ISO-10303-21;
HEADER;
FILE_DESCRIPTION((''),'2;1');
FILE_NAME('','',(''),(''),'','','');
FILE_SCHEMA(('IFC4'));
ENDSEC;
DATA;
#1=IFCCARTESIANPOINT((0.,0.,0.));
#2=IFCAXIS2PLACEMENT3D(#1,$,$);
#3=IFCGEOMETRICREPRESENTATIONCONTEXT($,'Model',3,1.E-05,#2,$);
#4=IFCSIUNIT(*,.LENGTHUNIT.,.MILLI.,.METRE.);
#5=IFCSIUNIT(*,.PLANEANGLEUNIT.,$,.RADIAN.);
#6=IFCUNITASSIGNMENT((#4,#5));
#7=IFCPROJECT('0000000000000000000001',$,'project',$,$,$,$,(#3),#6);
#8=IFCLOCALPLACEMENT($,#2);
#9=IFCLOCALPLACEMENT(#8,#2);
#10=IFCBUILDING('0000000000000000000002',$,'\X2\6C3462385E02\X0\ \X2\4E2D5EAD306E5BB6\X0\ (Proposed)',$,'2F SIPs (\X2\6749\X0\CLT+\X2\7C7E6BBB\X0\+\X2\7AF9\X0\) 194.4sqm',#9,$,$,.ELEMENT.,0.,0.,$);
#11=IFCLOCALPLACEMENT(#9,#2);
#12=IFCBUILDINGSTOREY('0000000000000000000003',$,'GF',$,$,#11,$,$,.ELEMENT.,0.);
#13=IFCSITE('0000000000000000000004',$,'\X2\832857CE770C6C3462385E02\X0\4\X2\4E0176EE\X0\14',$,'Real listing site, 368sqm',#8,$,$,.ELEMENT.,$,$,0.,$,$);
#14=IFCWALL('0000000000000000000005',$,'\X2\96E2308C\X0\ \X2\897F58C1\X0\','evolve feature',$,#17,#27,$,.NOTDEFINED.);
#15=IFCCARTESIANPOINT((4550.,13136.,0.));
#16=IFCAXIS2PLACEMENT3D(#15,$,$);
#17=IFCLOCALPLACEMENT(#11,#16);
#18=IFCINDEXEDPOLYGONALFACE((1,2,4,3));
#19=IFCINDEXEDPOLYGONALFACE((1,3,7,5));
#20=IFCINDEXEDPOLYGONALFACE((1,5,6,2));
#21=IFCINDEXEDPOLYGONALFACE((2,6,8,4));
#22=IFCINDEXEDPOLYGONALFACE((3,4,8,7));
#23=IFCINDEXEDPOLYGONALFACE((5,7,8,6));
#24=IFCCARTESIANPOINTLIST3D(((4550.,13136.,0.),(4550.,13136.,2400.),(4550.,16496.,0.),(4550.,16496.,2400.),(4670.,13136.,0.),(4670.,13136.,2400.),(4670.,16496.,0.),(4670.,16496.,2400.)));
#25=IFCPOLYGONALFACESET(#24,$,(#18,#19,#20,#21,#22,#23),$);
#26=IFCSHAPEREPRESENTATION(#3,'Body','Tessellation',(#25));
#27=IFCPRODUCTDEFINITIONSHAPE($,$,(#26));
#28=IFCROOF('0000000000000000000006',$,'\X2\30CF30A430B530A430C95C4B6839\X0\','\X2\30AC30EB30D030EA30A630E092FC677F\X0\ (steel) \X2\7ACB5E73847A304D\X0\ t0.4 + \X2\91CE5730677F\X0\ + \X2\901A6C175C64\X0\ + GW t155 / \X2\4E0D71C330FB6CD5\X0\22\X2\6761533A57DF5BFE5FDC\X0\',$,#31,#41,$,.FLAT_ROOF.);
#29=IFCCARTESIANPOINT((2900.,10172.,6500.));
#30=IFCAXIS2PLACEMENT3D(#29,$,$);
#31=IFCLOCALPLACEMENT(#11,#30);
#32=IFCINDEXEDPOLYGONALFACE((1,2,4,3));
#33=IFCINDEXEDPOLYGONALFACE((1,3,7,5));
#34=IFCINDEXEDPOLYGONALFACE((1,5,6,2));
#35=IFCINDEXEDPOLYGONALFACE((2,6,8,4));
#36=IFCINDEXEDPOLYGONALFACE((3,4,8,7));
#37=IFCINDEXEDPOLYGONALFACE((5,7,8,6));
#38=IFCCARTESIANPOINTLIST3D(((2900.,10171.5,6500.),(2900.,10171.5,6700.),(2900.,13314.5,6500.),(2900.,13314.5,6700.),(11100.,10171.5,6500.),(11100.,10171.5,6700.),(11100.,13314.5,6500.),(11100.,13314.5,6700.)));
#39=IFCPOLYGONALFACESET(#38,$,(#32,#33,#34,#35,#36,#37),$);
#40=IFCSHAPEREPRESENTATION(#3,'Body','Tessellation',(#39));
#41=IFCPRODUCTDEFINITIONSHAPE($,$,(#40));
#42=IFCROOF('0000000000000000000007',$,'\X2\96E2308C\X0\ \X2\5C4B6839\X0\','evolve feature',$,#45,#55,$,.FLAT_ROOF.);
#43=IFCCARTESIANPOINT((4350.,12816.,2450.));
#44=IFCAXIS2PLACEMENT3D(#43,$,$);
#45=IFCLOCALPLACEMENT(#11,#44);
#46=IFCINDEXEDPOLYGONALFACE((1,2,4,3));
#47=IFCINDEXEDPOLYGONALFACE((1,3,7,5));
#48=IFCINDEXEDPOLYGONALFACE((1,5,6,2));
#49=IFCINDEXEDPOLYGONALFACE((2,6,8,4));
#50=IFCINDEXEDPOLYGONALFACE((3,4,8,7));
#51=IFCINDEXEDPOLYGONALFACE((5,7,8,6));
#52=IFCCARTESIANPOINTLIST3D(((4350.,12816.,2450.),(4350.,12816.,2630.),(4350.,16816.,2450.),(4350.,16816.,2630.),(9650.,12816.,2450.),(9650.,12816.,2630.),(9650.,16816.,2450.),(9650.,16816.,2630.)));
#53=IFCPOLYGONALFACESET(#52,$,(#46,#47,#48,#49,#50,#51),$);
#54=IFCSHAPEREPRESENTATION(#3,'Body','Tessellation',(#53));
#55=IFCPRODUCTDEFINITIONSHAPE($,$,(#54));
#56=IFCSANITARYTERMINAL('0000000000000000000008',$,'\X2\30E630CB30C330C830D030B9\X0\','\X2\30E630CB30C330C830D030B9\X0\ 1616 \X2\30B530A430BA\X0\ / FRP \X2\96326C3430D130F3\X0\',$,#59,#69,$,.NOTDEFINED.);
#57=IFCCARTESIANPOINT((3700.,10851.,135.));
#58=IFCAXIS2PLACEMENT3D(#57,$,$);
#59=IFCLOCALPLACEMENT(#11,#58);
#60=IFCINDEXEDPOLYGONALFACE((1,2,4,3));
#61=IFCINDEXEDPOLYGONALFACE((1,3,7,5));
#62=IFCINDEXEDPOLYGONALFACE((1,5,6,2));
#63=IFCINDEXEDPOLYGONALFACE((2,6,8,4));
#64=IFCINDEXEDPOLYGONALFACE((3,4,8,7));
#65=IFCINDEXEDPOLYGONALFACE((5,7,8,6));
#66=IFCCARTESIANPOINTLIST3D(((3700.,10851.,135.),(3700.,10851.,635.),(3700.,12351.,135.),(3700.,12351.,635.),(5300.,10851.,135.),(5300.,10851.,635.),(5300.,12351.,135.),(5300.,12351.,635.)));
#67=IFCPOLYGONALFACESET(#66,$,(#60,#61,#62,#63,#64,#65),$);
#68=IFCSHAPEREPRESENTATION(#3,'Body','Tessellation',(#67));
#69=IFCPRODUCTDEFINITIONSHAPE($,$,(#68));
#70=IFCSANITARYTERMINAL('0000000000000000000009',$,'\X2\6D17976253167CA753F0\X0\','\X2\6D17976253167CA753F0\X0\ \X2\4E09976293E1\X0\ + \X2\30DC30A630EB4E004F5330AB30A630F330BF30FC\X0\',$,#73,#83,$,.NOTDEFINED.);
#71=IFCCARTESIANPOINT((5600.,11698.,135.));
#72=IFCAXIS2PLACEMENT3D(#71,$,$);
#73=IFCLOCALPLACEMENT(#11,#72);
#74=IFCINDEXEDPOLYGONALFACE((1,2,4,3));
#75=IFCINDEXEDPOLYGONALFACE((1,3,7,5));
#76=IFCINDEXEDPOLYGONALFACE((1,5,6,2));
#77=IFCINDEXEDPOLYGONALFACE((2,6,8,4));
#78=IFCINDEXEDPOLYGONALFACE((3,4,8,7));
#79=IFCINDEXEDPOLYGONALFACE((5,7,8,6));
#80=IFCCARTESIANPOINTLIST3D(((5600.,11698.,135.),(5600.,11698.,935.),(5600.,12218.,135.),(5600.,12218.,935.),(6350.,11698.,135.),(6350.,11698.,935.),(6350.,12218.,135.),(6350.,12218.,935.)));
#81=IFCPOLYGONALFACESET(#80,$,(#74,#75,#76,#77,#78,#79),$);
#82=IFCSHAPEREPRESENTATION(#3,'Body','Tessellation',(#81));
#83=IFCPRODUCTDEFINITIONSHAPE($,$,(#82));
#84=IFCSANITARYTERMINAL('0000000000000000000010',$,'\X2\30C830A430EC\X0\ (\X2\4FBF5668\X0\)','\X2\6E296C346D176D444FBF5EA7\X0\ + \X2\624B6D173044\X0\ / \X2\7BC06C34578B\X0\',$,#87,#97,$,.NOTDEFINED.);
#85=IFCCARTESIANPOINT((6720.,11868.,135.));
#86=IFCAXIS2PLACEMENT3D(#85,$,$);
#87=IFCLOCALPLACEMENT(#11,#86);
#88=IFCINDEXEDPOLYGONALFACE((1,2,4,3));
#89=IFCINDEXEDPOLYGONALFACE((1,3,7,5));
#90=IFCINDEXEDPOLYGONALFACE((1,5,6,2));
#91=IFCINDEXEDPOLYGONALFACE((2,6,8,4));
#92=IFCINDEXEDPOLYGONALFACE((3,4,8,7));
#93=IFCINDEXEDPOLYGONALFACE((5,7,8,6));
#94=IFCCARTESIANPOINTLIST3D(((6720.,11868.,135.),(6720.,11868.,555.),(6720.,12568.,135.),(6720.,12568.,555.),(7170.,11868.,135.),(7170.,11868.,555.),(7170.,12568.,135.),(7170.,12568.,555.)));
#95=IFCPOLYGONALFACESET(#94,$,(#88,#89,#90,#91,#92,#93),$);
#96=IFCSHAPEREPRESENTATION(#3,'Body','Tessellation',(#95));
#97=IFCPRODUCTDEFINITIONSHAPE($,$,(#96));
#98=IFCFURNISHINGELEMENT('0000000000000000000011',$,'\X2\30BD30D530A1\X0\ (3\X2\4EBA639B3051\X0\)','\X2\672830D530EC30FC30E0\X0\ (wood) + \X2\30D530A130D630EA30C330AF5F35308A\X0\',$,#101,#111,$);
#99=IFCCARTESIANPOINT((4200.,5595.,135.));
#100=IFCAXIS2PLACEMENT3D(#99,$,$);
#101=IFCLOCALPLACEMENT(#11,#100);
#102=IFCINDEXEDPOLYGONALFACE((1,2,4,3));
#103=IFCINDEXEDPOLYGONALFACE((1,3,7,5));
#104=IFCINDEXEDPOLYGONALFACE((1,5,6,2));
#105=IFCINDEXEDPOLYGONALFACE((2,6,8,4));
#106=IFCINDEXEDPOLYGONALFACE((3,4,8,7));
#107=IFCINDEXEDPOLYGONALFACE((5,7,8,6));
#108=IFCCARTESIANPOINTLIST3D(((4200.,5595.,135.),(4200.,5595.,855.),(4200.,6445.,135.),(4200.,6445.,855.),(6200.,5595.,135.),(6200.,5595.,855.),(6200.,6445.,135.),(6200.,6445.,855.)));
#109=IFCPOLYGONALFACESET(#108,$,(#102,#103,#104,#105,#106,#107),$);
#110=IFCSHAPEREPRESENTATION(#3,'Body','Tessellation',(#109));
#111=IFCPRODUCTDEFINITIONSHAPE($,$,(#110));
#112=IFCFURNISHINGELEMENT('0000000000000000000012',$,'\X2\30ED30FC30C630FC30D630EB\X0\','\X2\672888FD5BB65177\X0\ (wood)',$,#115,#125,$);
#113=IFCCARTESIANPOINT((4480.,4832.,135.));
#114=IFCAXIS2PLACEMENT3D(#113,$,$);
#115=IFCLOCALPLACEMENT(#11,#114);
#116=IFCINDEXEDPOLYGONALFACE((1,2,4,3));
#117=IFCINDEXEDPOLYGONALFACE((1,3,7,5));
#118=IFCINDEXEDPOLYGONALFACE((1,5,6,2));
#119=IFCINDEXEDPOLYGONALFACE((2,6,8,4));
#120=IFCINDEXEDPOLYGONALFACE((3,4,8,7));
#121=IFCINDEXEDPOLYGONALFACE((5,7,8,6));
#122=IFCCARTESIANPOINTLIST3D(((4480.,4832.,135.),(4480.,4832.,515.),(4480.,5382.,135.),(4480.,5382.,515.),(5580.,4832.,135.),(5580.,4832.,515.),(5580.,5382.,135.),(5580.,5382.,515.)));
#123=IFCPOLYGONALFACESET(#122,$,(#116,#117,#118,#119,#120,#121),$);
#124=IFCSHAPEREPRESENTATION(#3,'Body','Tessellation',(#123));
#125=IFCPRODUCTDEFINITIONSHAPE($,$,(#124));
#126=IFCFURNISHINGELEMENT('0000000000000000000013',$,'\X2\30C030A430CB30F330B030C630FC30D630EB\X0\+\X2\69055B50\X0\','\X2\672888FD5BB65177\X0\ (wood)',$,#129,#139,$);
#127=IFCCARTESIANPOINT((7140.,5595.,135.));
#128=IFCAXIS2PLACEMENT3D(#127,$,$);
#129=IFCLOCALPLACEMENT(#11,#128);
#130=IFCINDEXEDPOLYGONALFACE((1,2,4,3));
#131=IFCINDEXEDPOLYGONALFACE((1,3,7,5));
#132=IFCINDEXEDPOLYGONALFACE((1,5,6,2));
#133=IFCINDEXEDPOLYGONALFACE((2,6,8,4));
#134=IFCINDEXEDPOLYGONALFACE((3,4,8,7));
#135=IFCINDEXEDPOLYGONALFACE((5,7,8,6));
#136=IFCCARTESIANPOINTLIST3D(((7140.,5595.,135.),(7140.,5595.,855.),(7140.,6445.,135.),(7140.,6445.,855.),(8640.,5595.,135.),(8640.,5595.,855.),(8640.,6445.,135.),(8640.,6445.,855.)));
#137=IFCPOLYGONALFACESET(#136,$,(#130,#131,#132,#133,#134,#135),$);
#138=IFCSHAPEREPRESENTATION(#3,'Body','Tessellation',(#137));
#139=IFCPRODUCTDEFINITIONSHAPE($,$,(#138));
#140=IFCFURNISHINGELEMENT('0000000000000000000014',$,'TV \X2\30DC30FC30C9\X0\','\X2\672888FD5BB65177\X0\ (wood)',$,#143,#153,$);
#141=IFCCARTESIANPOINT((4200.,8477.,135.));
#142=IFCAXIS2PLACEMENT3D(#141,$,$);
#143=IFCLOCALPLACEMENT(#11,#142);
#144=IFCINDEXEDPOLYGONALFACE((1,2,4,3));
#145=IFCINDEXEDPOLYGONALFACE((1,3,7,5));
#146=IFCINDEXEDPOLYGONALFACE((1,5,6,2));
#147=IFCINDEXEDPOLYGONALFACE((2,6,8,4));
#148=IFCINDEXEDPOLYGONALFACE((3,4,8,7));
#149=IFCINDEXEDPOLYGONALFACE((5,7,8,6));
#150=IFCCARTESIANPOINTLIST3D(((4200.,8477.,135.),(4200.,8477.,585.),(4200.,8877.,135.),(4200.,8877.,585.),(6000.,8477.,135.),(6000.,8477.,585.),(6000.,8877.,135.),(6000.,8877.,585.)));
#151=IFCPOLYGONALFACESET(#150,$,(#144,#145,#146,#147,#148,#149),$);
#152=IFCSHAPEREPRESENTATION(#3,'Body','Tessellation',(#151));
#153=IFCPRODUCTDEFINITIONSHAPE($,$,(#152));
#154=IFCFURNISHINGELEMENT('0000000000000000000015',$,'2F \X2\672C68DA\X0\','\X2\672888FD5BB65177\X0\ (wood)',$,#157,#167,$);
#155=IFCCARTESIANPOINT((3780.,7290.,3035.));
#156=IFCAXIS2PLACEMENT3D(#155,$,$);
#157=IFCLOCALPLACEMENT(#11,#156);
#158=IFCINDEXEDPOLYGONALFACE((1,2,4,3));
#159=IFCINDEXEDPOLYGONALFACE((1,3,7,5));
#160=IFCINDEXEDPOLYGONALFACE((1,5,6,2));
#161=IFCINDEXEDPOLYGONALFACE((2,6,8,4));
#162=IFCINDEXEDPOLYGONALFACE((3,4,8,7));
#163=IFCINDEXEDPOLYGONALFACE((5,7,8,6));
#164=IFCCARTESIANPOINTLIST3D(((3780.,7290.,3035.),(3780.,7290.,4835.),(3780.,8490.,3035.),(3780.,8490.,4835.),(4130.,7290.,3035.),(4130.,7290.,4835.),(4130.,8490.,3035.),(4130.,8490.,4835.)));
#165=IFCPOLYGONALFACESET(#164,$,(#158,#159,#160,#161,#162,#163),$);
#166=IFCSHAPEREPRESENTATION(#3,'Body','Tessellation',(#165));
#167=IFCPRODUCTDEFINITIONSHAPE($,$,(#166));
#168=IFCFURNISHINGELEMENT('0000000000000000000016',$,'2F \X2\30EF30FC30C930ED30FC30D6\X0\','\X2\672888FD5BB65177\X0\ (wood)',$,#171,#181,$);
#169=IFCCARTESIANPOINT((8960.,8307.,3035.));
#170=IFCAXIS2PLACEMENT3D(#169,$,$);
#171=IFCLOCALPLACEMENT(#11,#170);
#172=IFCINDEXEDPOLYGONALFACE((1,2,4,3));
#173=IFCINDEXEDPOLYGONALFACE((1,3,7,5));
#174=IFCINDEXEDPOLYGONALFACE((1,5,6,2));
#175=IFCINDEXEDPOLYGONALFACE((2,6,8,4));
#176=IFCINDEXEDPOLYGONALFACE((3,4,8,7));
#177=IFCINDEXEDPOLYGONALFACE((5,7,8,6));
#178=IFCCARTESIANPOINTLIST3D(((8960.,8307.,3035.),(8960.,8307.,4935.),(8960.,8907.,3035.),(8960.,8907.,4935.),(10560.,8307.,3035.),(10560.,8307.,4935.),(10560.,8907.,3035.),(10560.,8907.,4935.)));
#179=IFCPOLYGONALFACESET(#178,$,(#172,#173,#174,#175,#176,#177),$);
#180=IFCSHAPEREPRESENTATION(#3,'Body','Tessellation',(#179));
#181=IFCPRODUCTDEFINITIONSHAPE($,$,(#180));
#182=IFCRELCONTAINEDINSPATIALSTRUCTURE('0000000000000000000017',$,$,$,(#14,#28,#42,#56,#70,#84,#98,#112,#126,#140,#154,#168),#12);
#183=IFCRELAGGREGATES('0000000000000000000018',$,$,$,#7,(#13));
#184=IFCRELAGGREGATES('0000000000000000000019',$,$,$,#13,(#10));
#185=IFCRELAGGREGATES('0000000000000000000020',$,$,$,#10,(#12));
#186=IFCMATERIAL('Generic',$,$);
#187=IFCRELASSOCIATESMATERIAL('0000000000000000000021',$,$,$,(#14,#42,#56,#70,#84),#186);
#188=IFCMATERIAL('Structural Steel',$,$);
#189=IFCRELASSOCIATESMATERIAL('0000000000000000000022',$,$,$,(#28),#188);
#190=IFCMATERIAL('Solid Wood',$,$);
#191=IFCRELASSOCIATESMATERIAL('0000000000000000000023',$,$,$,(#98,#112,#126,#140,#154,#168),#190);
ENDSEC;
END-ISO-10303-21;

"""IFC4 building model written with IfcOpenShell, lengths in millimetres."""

from ifc_helpers import new_model, si_unit, frame, frame_2d, origin, place, context, project, spatial, rectangle, extrude, material, element, save


model = new_model("IFC4")

# Units and contexts
model_context = context("Model", 3, precision=1e-05, world=origin())
ifc_project = project(units=[si_unit("LENGTHUNIT", "METRE", prefix="MILLI"), si_unit("PLANEANGLEUNIT", "RADIAN")], contexts=[model_context])

# Site, building, storey
site_placement = place(None, origin())
site = spatial("IfcSite", under=ifc_project, at=site_placement, Name="茨城県水戸市4丁目14", ObjectType="Real listing site, 368sqm", CompositionType="ELEMENT", RefElevation=0.0)
building_placement = place(site_placement, origin())
building = spatial("IfcBuilding", under=site, at=building_placement, Name="水戸市 中庭の家 (Proposed)", ObjectType="2F SIPs (杉CLT+籾殻+竹) 194.4sqm", CompositionType="ELEMENT", ElevationOfRefHeight=0.0, ElevationOfTerrain=0.0)
storey_placement = place(building_placement, origin())
storey = spatial("IfcBuildingStorey", under=building, at=storey_placement, Name="GF", CompositionType="ELEMENT", Elevation=0.0)

# Shared definitions
ifc_material_1 = material(Name="Generic")

# Shared definitions
ifc_material_2 = material(Name="Solid Wood")

# Wall
wall_1_placement = place(storey_placement, frame((4550.0, 13136.0, 0.0)))
element("IfcWall", 1, at=wall_1_placement, inside=storey, material=ifc_material_1, Name="離れ 西壁", Description="evolve feature", PredefinedType="NOTDEFINED", context=model_context, shape_type="SweptSolid", body=[
    extrude(rectangle(XDim=120.0, YDim=3360.0, at=frame_2d((60.0, 1680.0))), frame((4550.0, 13136.0, 0.0)), (0.0, 0.0, 1.0), 2400.0),
])

# Roofs
ifc_material_3 = material(Name="Structural Steel")
roof_1_placement = place(storey_placement, frame((2900.0, 10172.0, 6500.0)))
element("IfcRoof", 2, at=roof_1_placement, inside=storey, material=ifc_material_3, Name="ハイサイド屋根", Description="ガルバリウム鋼板 (steel) 立平葺き t0.4 + 野地板 + 通気層 + GW t155 / 不燃・法22条区域対応", PredefinedType="FLAT_ROOF", context=model_context, shape_type="SweptSolid", body=[
    extrude(rectangle(XDim=8200.0, YDim=3143.0, at=frame_2d((4100.0, 1571.0))), frame((2900.0, 10172.0, 6500.0)), (0.0, 0.0, 1.0), 200.0),
])
roof_2_placement = place(storey_placement, frame((4350.0, 12816.0, 2450.0)))
element("IfcRoof", 3, at=roof_2_placement, inside=storey, material=ifc_material_1, Name="離れ 屋根", Description="evolve feature", PredefinedType="FLAT_ROOF", context=model_context, shape_type="SweptSolid", body=[
    extrude(rectangle(XDim=5300.0, YDim=4000.0, at=frame_2d((2650.0, 2000.0))), frame((4350.0, 12816.0, 2450.0)), (0.0, 0.0, 1.0), 180.0),
])

# Sanitary terminals
sanitary_terminal_1_placement = place(storey_placement, frame((3700.0, 10851.0, 135.0)))
element("IfcSanitaryTerminal", 4, at=sanitary_terminal_1_placement, inside=storey, material=ifc_material_1, Name="ユニットバス", Description="ユニットバス 1616 サイズ / FRP 防水パン", PredefinedType="NOTDEFINED", context=model_context, shape_type="SweptSolid", body=[
    extrude(rectangle(XDim=1600.0, YDim=1500.0, at=frame_2d((800.0, 750.0))), frame((3700.0, 10851.0, 135.0)), (0.0, 0.0, 1.0), 500.0),
])
sanitary_terminal_2_placement = place(storey_placement, frame((5600.0, 11698.0, 135.0)))
element("IfcSanitaryTerminal", 5, at=sanitary_terminal_2_placement, inside=storey, material=ifc_material_1, Name="洗面化粧台", Description="洗面化粧台 三面鏡 + ボウル一体カウンター", PredefinedType="NOTDEFINED", context=model_context, shape_type="SweptSolid", body=[
    extrude(rectangle(XDim=750.0, YDim=520.0, at=frame_2d((375.0, 260.0))), frame((5600.0, 11698.0, 135.0)), (0.0, 0.0, 1.0), 800.0),
])
sanitary_terminal_3_placement = place(storey_placement, frame((6720.0, 11868.0, 135.0)))
element("IfcSanitaryTerminal", 6, at=sanitary_terminal_3_placement, inside=storey, material=ifc_material_1, Name="トイレ (便器)", Description="温水洗浄便座 + 手洗い / 節水型", PredefinedType="NOTDEFINED", context=model_context, shape_type="SweptSolid", body=[
    extrude(rectangle(XDim=450.0, YDim=700.0, at=frame_2d((225.0, 350.0))), frame((6720.0, 11868.0, 135.0)), (0.0, 0.0, 1.0), 420.0),
])

# Furnishing elements
furnishing_1_placement = place(storey_placement, frame((4200.0, 5595.0, 135.0)))
element("IfcFurnishingElement", 7, at=furnishing_1_placement, inside=storey, material=ifc_material_2, Name="ソファ (3人掛け)", Description="木フレーム (wood) + ファブリック張り", context=model_context, shape_type="SweptSolid", body=[
    extrude(rectangle(XDim=2000.0, YDim=850.0, at=frame_2d((1000.0, 425.0))), frame((4200.0, 5595.0, 135.0)), (0.0, 0.0, 1.0), 720.0),
])
furnishing_2_placement = place(storey_placement, frame((4480.0, 4832.0, 135.0)))
element("IfcFurnishingElement", 8, at=furnishing_2_placement, inside=storey, material=ifc_material_2, Name="ローテーブル", Description="木製家具 (wood)", context=model_context, shape_type="SweptSolid", body=[
    extrude(rectangle(XDim=1100.0, YDim=550.0, at=frame_2d((550.0, 275.0))), frame((4480.0, 4832.0, 135.0)), (0.0, 0.0, 1.0), 380.0),
])
furnishing_3_placement = place(storey_placement, frame((7140.0, 5595.0, 135.0)))
element("IfcFurnishingElement", 9, at=furnishing_3_placement, inside=storey, material=ifc_material_2, Name="ダイニングテーブル+椅子", Description="木製家具 (wood)", context=model_context, shape_type="SweptSolid", body=[
    extrude(rectangle(XDim=1500.0, YDim=850.0, at=frame_2d((750.0, 425.0))), frame((7140.0, 5595.0, 135.0)), (0.0, 0.0, 1.0), 720.0),
])
furnishing_4_placement = place(storey_placement, frame((4200.0, 8477.0, 135.0)))
element("IfcFurnishingElement", 10, at=furnishing_4_placement, inside=storey, material=ifc_material_2, Name="TV ボード", Description="木製家具 (wood)", context=model_context, shape_type="SweptSolid", body=[
    extrude(rectangle(XDim=1800.0, YDim=400.0, at=frame_2d((900.0, 200.0))), frame((4200.0, 8477.0, 135.0)), (0.0, 0.0, 1.0), 450.0),
])
furnishing_5_placement = place(storey_placement, frame((3780.0, 7290.0, 3035.0)))
element("IfcFurnishingElement", 11, at=furnishing_5_placement, inside=storey, material=ifc_material_2, Name="2F 本棚", Description="木製家具 (wood)", context=model_context, shape_type="SweptSolid", body=[
    extrude(rectangle(XDim=350.0, YDim=1200.0, at=frame_2d((175.0, 600.0))), frame((3780.0, 7290.0, 3035.0)), (0.0, 0.0, 1.0), 1800.0),
])
furnishing_6_placement = place(storey_placement, frame((8960.0, 8307.0, 3035.0)))
element("IfcFurnishingElement", 12, at=furnishing_6_placement, inside=storey, material=ifc_material_2, Name="2F ワードローブ", Description="木製家具 (wood)", context=model_context, shape_type="SweptSolid", body=[
    extrude(rectangle(XDim=1600.0, YDim=600.0, at=frame_2d((800.0, 300.0))), frame((8960.0, 8307.0, 3035.0)), (0.0, 0.0, 1.0), 1900.0),
])

save(model, "model.ifc")
